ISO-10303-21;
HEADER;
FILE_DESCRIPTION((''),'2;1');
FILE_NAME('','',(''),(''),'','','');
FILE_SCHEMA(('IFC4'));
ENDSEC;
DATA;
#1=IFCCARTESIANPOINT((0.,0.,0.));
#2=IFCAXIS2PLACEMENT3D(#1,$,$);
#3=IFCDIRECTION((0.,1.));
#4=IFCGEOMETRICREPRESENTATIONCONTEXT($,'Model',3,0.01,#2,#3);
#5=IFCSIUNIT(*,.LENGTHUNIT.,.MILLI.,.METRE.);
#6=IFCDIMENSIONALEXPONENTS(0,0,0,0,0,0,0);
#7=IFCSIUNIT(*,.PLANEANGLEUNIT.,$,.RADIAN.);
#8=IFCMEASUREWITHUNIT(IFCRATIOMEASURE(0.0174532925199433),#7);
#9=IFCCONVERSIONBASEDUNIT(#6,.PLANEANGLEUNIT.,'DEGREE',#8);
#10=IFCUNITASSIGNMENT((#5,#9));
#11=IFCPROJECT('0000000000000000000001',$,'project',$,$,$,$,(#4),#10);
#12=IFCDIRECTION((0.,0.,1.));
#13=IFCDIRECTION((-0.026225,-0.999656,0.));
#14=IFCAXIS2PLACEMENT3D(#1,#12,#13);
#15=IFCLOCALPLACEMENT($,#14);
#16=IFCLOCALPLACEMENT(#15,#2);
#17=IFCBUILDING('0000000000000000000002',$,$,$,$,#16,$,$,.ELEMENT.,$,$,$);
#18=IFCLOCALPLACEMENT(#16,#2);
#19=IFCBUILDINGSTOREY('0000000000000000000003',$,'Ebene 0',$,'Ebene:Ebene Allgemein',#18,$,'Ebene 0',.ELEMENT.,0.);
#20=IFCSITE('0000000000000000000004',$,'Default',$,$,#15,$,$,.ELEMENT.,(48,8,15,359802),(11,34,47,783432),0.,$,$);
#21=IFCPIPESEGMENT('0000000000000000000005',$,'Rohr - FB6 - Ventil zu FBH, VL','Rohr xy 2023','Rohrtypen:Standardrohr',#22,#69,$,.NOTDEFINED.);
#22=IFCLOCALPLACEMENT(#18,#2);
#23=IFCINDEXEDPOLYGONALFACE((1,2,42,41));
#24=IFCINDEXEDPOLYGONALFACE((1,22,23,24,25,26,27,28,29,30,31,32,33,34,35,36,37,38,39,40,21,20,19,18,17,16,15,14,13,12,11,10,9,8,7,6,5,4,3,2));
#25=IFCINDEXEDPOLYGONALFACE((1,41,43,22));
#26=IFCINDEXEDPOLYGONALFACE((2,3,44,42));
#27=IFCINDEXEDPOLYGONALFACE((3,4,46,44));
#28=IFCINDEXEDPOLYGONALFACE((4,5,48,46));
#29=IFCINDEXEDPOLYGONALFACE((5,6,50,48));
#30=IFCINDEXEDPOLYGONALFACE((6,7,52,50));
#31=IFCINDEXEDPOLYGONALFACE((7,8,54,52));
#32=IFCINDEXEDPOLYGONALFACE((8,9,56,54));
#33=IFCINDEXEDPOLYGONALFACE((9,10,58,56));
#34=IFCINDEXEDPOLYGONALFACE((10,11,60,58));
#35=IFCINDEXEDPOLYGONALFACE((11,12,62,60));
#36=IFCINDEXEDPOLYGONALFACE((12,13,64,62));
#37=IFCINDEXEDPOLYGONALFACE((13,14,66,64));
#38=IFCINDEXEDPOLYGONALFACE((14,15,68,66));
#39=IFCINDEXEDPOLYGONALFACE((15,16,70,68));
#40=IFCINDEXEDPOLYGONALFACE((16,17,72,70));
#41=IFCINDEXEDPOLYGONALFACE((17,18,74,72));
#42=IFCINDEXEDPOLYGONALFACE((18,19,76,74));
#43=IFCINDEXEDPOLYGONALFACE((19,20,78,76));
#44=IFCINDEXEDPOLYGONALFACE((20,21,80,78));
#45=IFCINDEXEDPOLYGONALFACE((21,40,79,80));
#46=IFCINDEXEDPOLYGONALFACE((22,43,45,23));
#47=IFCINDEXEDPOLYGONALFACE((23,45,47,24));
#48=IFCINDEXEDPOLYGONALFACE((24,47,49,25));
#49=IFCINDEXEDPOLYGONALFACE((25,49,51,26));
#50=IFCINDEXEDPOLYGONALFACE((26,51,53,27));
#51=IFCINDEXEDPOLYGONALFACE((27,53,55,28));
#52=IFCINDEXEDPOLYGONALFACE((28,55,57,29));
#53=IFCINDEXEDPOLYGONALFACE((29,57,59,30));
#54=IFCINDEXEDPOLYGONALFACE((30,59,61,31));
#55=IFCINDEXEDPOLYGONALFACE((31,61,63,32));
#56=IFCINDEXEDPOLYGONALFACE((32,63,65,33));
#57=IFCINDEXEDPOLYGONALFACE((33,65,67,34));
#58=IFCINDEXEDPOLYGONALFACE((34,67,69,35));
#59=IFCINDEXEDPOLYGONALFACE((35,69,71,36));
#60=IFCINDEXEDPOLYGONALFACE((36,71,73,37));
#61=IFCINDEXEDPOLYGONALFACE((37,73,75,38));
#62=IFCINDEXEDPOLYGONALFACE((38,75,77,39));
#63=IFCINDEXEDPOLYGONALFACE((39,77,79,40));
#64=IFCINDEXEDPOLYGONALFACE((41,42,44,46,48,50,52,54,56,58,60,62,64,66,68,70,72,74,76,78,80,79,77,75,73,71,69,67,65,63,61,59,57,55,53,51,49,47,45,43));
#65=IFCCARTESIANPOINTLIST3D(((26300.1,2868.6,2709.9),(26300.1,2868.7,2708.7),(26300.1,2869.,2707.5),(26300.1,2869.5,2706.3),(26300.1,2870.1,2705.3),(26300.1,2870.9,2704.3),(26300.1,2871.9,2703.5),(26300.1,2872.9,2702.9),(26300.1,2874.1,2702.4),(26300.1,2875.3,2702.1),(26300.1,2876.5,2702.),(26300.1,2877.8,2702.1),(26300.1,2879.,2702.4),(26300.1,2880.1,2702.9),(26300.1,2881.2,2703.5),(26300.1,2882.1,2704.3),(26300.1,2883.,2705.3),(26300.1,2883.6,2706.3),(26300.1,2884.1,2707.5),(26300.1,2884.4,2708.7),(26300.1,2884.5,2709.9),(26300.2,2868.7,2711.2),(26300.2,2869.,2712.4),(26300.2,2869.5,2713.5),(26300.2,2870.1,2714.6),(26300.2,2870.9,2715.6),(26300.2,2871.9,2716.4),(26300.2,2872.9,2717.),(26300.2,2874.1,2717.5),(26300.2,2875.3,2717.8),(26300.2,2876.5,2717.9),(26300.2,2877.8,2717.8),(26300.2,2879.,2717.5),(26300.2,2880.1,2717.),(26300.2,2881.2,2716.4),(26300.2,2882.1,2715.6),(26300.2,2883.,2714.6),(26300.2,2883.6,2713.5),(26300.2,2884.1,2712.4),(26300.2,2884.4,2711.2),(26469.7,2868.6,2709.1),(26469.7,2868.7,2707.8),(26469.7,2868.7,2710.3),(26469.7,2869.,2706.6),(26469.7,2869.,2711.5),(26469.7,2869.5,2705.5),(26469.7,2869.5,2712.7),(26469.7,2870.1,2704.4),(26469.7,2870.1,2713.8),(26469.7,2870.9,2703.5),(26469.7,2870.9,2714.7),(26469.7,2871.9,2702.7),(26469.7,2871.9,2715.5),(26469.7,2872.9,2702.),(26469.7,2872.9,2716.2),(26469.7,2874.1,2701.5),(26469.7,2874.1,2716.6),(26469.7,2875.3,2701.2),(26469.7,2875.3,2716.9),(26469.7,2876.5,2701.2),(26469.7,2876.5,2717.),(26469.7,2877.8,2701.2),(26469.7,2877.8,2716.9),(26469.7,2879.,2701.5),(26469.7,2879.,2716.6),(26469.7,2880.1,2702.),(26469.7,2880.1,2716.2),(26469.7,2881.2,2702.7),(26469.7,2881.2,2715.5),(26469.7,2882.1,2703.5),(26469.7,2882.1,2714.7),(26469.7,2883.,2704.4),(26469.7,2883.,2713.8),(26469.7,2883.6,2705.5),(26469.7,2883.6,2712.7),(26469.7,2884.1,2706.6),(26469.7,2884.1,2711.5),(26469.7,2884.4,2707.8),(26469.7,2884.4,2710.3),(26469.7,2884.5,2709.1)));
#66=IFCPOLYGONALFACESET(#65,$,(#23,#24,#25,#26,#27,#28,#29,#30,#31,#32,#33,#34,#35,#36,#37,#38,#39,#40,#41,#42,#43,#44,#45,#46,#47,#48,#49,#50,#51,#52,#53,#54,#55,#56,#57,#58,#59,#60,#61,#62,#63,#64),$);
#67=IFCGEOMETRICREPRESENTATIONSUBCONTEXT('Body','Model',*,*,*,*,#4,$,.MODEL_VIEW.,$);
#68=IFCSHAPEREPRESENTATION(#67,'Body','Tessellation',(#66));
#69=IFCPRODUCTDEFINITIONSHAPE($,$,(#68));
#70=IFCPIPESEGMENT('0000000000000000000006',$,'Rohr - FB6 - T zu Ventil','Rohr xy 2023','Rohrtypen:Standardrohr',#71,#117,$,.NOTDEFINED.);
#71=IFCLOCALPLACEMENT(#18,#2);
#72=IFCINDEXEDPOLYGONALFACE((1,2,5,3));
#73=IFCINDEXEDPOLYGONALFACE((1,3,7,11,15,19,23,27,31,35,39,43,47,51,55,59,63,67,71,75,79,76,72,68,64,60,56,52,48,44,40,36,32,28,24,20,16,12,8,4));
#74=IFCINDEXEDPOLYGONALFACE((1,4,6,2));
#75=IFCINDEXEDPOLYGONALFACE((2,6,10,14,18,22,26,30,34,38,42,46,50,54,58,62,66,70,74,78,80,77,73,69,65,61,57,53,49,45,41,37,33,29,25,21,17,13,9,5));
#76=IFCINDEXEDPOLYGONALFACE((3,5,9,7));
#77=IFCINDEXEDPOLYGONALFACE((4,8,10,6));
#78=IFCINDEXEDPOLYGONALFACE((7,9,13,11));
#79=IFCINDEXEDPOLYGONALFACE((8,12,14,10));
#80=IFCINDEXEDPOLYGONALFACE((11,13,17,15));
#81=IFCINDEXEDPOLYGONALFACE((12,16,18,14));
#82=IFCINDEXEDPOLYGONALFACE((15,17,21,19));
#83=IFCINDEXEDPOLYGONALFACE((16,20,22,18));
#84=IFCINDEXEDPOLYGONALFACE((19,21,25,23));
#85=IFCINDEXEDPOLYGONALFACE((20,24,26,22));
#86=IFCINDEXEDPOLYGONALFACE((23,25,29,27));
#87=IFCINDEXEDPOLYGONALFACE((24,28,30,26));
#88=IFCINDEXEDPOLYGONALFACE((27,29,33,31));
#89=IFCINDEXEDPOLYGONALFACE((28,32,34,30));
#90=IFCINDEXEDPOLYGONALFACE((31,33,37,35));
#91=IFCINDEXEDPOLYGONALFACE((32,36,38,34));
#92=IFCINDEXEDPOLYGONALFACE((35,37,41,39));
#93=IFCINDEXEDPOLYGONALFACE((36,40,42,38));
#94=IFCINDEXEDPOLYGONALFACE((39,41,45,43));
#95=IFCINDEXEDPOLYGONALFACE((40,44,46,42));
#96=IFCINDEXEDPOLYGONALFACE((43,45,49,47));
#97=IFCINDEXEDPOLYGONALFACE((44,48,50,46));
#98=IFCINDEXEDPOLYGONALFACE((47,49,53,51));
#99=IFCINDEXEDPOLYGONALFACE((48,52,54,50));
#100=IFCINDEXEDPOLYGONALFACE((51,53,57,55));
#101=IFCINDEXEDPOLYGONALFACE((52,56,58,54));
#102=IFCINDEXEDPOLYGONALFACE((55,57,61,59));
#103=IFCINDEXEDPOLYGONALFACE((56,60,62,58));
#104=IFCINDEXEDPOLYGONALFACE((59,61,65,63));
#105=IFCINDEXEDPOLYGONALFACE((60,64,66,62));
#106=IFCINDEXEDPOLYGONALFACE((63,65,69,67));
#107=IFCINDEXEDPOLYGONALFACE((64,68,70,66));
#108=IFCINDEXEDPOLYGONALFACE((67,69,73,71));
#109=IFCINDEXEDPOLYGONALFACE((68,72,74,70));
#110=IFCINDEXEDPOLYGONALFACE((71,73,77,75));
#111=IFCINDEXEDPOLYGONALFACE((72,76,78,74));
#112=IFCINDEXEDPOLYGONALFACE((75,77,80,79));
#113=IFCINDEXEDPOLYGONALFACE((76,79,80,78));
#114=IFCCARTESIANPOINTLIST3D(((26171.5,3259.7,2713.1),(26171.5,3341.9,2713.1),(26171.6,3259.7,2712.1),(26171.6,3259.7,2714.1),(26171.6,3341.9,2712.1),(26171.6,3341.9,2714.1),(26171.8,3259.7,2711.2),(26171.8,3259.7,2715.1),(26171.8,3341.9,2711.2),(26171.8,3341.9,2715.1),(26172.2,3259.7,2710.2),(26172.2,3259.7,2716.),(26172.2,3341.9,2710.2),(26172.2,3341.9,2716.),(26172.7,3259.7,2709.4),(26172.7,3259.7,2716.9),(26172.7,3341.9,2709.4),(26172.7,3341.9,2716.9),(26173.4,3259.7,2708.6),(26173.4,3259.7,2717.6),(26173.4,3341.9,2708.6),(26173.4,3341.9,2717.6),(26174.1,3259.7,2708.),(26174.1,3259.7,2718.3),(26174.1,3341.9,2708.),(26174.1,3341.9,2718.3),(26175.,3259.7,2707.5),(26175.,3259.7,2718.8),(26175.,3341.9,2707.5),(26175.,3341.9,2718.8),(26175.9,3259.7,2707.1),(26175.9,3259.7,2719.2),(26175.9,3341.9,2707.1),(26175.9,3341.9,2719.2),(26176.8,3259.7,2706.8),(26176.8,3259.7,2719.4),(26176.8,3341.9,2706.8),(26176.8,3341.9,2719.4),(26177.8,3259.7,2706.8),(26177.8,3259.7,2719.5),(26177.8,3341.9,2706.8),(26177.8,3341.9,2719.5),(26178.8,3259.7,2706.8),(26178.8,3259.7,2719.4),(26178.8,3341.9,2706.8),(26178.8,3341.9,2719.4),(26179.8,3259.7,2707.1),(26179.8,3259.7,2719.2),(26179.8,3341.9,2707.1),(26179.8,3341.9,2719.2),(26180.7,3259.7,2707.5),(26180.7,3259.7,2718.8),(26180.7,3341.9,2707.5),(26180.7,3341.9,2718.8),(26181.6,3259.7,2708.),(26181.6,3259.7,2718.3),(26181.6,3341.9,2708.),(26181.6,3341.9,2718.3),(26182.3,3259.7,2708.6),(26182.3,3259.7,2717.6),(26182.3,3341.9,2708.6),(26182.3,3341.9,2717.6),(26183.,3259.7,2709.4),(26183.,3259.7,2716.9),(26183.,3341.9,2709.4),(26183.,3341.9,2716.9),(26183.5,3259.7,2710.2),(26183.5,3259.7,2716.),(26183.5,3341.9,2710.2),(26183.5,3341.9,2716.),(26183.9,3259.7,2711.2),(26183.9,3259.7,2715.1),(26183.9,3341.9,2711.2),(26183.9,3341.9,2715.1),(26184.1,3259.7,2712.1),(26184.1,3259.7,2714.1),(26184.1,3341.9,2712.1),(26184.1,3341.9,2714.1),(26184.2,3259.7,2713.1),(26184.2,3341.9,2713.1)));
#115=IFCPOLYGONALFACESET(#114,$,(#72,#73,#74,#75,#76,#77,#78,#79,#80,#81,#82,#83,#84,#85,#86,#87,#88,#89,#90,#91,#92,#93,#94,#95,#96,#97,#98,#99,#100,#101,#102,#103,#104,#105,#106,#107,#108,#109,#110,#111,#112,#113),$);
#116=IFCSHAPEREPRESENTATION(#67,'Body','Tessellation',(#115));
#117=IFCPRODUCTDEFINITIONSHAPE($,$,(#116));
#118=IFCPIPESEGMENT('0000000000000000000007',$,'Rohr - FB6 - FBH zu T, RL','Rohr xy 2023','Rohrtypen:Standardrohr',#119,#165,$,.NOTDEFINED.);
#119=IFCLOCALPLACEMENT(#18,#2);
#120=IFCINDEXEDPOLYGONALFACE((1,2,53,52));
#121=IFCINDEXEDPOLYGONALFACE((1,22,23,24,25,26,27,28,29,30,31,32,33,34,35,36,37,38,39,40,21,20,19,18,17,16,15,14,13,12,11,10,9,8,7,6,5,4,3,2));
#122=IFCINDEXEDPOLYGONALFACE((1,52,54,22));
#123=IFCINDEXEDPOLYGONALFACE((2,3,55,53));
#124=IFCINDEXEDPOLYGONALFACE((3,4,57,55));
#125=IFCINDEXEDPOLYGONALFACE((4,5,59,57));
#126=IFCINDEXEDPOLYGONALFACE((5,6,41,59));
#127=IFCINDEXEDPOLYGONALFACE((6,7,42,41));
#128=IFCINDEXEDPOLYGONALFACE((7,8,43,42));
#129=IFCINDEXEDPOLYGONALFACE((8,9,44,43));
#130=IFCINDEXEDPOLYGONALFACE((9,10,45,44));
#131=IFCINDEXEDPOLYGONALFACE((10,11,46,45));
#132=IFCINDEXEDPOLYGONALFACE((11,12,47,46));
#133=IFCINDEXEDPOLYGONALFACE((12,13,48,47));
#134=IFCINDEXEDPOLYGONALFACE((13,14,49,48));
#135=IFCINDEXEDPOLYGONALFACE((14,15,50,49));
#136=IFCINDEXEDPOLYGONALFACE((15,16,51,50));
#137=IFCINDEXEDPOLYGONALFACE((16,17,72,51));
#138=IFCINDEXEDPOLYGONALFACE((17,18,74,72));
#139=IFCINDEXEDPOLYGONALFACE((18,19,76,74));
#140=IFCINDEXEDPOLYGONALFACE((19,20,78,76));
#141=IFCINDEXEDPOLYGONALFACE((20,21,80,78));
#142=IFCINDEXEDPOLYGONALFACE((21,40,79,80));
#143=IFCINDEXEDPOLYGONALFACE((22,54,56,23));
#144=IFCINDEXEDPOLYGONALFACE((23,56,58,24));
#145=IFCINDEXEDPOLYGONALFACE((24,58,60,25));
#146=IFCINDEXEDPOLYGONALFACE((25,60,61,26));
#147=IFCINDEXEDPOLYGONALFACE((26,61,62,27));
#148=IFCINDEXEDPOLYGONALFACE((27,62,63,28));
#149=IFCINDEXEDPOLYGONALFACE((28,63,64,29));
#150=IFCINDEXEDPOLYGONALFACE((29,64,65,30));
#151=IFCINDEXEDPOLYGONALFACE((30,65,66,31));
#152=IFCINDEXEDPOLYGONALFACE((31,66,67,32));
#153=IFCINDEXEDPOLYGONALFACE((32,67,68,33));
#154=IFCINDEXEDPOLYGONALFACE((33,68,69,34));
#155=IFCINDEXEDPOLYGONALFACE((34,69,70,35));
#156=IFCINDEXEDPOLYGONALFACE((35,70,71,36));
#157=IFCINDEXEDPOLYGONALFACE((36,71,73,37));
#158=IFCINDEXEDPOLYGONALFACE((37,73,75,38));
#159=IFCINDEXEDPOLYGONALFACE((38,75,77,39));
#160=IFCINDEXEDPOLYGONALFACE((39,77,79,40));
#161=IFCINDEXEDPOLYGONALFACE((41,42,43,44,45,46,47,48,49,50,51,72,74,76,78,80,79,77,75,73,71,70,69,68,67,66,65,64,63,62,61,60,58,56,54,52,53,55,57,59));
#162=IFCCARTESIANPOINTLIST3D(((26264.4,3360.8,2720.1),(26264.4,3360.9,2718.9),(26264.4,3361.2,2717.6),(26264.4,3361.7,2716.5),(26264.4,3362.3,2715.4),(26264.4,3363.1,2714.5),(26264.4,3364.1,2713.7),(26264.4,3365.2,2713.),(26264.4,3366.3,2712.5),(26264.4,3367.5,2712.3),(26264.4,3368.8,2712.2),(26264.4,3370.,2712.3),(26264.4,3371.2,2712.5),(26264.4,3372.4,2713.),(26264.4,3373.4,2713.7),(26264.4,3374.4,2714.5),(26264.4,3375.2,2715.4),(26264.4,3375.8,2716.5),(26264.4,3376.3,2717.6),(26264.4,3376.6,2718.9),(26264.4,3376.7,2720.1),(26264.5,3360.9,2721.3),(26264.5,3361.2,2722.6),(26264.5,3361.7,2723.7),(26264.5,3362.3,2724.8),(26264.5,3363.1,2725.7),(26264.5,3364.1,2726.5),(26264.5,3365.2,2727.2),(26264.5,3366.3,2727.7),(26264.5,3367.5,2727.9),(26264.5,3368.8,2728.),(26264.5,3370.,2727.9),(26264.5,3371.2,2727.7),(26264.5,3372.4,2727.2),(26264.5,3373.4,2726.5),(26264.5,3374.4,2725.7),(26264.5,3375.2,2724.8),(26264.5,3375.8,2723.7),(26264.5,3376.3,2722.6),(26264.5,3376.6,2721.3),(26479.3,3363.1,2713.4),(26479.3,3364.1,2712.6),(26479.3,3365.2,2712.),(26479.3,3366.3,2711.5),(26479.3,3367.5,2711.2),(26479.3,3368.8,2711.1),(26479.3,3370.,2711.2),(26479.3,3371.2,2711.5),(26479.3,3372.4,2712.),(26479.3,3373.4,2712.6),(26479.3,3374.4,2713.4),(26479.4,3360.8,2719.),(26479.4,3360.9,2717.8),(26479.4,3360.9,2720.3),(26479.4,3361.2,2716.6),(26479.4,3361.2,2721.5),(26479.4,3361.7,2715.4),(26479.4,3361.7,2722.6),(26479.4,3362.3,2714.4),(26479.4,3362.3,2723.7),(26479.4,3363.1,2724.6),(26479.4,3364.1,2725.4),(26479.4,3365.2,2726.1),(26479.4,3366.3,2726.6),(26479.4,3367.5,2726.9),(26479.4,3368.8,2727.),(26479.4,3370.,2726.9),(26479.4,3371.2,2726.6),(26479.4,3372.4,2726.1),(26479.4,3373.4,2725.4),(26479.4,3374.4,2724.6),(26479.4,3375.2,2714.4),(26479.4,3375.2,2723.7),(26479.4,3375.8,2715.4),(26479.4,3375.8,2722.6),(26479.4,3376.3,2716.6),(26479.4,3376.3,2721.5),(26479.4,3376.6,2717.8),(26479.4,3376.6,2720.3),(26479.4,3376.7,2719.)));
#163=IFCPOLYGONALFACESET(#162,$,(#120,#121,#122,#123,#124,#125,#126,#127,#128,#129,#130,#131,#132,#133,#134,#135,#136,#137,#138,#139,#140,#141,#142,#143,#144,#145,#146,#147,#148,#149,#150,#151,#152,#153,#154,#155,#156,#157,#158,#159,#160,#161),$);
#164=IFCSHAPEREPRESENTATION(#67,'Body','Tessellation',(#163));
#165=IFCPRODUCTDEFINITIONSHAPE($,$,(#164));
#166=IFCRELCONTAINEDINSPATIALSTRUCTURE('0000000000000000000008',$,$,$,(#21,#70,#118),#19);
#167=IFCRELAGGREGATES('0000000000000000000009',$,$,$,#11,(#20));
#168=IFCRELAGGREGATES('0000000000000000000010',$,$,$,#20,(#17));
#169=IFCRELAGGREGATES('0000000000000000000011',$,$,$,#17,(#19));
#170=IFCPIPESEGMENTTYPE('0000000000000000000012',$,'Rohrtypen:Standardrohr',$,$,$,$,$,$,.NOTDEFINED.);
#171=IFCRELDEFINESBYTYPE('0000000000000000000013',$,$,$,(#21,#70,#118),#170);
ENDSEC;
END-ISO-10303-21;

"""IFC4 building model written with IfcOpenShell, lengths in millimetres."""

from ifc_helpers import new_model, entity, si_unit, converted_unit, direction, frame, origin, place, context, subcontext, project, spatial, indexed_curve, outline, extrude, type_object, element, save


model = new_model("IFC4")

# Units and contexts
model_context = context("Model", 3, precision=0.01, world=origin(), true_north=direction((0.0, 1.0)))
body_context = subcontext(model_context, "Body", "Model", "MODEL_VIEW")
ifc_project = project(units=[si_unit("LENGTHUNIT", "METRE", prefix="MILLI"), converted_unit("PLANEANGLEUNIT", "DEGREE", entity("IfcRatioMeasure", 0.0174532925199433), si_unit("PLANEANGLEUNIT", "RADIAN"), dimensions=[0, 0, 0, 0, 0, 0, 0])], contexts=[model_context])

# Site, building, storey
site_placement = place(None, frame((0.0, 0.0, 0.0), z_axis=(0.0, 0.0, 1.0), x_axis=(-0.026225, -0.999656, 0.0)))
site = spatial("IfcSite", under=ifc_project, at=site_placement, Name="Default", CompositionType="ELEMENT", RefLatitude=(48, 8, 15, 359802), RefLongitude=(11, 34, 47, 783432), RefElevation=0.0)
building_placement = place(site_placement, origin())
building = spatial("IfcBuilding", under=site, at=building_placement, CompositionType="ELEMENT")
storey_placement = place(building_placement, origin())
storey = spatial("IfcBuildingStorey", under=building, at=storey_placement, Name="Ebene 0", ObjectType="Ebene:Ebene Allgemein", LongName="Ebene 0", CompositionType="ELEMENT", Elevation=0.0)

# Pipe segments
pipe_segment_type = type_object("IfcPipeSegmentType", Name="Rohrtypen:Standardrohr", PredefinedType="NOTDEFINED")
pipe_segment_1_placement = place(storey_placement, origin())
element("IfcPipeSegment", 1, at=pipe_segment_1_placement, inside=storey, type_object=pipe_segment_type, Name="Rohr - FB6 - Ventil zu FBH, VL", Description="Rohr xy 2023", ObjectType="Rohrtypen:Standardrohr", PredefinedType="NOTDEFINED", context=body_context, shape_type="SweptSolid", body=[
    extrude(outline(indexed_curve([(7.9, 0.0), (7.8, 1.2), (7.6, 2.5), (7.1, 3.6), (6.4, 4.7), (5.6, 5.6), (4.7, 6.4), (3.6, 7.1), (2.5, 7.6), (1.2, 7.8), (0.0, 7.9), (-1.2, 7.8), (-2.5, 7.6), (-3.6, 7.1), (-4.7, 6.4), (-5.6, 5.6), (-6.4, 4.7), (-7.1, 3.6), (-7.6, 2.5), (-7.8, 1.2), (-7.9, 0.0), (-7.8, -1.2), (-7.6, -2.5), (-7.1, -3.6), (-6.4, -4.7), (-5.6, -5.6), (-4.7, -6.4), (-3.6, -7.1), (-2.5, -7.6), (-1.2, -7.8), (0.0, -7.9), (1.2, -7.8), (2.5, -7.6), (3.6, -7.1), (4.7, -6.4), (5.6, -5.6), (6.4, -4.7), (7.1, -3.6), (7.6, -2.5), (7.8, -1.2), (7.9, 0.0)], self_intersect=False)), frame((26300.1, 2876.5, 2709.9), z_axis=(0.999988, 0.0, -0.005), x_axis=(0.0, 1.0, 0.0)), (0.0, 0.0, 1.0), 169.5),
])
pipe_segment_2_placement = place(storey_placement, origin())
element("IfcPipeSegment", 2, at=pipe_segment_2_placement, inside=storey, type_object=pipe_segment_type, Name="Rohr - FB6 - T zu Ventil", Description="Rohr xy 2023", ObjectType="Rohrtypen:Standardrohr", PredefinedType="NOTDEFINED", context=body_context, shape_type="SweptSolid", body=[
    extrude(outline(indexed_curve([(6.3, 0.0), (6.3, 1.0), (6.0, 2.0), (5.7, 2.9), (5.1, 3.7), (4.5, 4.5), (3.7, 5.1), (2.9, 5.7), (2.0, 6.0), (1.0, 6.3), (0.0, 6.4), (-1.0, 6.3), (-2.0, 6.0), (-2.9, 5.7), (-3.7, 5.1), (-4.5, 4.5), (-5.1, 3.7), (-5.7, 2.9), (-6.0, 2.0), (-6.3, 1.0), (-6.3, 0.0), (-6.3, -1.0), (-6.0, -2.0), (-5.7, -2.9), (-5.1, -3.7), (-4.5, -4.5), (-3.7, -5.1), (-2.9, -5.7), (-2.0, -6.0), (-1.0, -6.3), (0.0, -6.4), (1.0, -6.3), (2.0, -6.0), (2.9, -5.7), (3.7, -5.1), (4.5, -4.5), (5.1, -3.7), (5.7, -2.9), (6.0, -2.0), (6.3, -1.0), (6.3, 0.0)], self_intersect=False)), frame((26177.8, 3259.7, 2713.1), z_axis=(0.0, 1.0, 0.0), x_axis=(-1.0, 0.0, 0.0)), (0.0, 0.0, 1.0), 82.2),
])
pipe_segment_3_placement = place(storey_placement, origin())
element("IfcPipeSegment", 3, at=pipe_segment_3_placement, inside=storey, type_object=pipe_segment_type, Name="Rohr - FB6 - FBH zu T, RL", Description="Rohr xy 2023", ObjectType="Rohrtypen:Standardrohr", PredefinedType="NOTDEFINED", context=body_context, shape_type="SweptSolid", body=[
    extrude(outline(indexed_curve([(7.9, 0.0), (7.8, 1.2), (7.6, 2.5), (7.1, 3.6), (6.4, 4.7), (5.6, 5.6), (4.7, 6.4), (3.6, 7.1), (2.5, 7.6), (1.2, 7.8), (0.0, 7.9), (-1.2, 7.8), (-2.5, 7.6), (-3.6, 7.1), (-4.7, 6.4), (-5.6, 5.6), (-6.4, 4.7), (-7.1, 3.6), (-7.6, 2.5), (-7.8, 1.2), (-7.9, 0.0), (-7.8, -1.2), (-7.6, -2.5), (-7.1, -3.6), (-6.4, -4.7), (-5.6, -5.6), (-4.7, -6.4), (-3.6, -7.1), (-2.5, -7.6), (-1.2, -7.8), (0.0, -7.9), (1.2, -7.8), (2.5, -7.6), (3.6, -7.1), (4.7, -6.4), (5.6, -5.6), (6.4, -4.7), (7.1, -3.6), (7.6, -2.5), (7.8, -1.2), (7.9, 0.0)], self_intersect=False)), frame((26479.4, 3368.8, 2719.0), z_axis=(-0.999988, 0.0, 0.005), x_axis=(0.0, 1.0, 0.0)), (0.0, 0.0, 1.0), 214.9),
])

save(model, "model.ifc")
